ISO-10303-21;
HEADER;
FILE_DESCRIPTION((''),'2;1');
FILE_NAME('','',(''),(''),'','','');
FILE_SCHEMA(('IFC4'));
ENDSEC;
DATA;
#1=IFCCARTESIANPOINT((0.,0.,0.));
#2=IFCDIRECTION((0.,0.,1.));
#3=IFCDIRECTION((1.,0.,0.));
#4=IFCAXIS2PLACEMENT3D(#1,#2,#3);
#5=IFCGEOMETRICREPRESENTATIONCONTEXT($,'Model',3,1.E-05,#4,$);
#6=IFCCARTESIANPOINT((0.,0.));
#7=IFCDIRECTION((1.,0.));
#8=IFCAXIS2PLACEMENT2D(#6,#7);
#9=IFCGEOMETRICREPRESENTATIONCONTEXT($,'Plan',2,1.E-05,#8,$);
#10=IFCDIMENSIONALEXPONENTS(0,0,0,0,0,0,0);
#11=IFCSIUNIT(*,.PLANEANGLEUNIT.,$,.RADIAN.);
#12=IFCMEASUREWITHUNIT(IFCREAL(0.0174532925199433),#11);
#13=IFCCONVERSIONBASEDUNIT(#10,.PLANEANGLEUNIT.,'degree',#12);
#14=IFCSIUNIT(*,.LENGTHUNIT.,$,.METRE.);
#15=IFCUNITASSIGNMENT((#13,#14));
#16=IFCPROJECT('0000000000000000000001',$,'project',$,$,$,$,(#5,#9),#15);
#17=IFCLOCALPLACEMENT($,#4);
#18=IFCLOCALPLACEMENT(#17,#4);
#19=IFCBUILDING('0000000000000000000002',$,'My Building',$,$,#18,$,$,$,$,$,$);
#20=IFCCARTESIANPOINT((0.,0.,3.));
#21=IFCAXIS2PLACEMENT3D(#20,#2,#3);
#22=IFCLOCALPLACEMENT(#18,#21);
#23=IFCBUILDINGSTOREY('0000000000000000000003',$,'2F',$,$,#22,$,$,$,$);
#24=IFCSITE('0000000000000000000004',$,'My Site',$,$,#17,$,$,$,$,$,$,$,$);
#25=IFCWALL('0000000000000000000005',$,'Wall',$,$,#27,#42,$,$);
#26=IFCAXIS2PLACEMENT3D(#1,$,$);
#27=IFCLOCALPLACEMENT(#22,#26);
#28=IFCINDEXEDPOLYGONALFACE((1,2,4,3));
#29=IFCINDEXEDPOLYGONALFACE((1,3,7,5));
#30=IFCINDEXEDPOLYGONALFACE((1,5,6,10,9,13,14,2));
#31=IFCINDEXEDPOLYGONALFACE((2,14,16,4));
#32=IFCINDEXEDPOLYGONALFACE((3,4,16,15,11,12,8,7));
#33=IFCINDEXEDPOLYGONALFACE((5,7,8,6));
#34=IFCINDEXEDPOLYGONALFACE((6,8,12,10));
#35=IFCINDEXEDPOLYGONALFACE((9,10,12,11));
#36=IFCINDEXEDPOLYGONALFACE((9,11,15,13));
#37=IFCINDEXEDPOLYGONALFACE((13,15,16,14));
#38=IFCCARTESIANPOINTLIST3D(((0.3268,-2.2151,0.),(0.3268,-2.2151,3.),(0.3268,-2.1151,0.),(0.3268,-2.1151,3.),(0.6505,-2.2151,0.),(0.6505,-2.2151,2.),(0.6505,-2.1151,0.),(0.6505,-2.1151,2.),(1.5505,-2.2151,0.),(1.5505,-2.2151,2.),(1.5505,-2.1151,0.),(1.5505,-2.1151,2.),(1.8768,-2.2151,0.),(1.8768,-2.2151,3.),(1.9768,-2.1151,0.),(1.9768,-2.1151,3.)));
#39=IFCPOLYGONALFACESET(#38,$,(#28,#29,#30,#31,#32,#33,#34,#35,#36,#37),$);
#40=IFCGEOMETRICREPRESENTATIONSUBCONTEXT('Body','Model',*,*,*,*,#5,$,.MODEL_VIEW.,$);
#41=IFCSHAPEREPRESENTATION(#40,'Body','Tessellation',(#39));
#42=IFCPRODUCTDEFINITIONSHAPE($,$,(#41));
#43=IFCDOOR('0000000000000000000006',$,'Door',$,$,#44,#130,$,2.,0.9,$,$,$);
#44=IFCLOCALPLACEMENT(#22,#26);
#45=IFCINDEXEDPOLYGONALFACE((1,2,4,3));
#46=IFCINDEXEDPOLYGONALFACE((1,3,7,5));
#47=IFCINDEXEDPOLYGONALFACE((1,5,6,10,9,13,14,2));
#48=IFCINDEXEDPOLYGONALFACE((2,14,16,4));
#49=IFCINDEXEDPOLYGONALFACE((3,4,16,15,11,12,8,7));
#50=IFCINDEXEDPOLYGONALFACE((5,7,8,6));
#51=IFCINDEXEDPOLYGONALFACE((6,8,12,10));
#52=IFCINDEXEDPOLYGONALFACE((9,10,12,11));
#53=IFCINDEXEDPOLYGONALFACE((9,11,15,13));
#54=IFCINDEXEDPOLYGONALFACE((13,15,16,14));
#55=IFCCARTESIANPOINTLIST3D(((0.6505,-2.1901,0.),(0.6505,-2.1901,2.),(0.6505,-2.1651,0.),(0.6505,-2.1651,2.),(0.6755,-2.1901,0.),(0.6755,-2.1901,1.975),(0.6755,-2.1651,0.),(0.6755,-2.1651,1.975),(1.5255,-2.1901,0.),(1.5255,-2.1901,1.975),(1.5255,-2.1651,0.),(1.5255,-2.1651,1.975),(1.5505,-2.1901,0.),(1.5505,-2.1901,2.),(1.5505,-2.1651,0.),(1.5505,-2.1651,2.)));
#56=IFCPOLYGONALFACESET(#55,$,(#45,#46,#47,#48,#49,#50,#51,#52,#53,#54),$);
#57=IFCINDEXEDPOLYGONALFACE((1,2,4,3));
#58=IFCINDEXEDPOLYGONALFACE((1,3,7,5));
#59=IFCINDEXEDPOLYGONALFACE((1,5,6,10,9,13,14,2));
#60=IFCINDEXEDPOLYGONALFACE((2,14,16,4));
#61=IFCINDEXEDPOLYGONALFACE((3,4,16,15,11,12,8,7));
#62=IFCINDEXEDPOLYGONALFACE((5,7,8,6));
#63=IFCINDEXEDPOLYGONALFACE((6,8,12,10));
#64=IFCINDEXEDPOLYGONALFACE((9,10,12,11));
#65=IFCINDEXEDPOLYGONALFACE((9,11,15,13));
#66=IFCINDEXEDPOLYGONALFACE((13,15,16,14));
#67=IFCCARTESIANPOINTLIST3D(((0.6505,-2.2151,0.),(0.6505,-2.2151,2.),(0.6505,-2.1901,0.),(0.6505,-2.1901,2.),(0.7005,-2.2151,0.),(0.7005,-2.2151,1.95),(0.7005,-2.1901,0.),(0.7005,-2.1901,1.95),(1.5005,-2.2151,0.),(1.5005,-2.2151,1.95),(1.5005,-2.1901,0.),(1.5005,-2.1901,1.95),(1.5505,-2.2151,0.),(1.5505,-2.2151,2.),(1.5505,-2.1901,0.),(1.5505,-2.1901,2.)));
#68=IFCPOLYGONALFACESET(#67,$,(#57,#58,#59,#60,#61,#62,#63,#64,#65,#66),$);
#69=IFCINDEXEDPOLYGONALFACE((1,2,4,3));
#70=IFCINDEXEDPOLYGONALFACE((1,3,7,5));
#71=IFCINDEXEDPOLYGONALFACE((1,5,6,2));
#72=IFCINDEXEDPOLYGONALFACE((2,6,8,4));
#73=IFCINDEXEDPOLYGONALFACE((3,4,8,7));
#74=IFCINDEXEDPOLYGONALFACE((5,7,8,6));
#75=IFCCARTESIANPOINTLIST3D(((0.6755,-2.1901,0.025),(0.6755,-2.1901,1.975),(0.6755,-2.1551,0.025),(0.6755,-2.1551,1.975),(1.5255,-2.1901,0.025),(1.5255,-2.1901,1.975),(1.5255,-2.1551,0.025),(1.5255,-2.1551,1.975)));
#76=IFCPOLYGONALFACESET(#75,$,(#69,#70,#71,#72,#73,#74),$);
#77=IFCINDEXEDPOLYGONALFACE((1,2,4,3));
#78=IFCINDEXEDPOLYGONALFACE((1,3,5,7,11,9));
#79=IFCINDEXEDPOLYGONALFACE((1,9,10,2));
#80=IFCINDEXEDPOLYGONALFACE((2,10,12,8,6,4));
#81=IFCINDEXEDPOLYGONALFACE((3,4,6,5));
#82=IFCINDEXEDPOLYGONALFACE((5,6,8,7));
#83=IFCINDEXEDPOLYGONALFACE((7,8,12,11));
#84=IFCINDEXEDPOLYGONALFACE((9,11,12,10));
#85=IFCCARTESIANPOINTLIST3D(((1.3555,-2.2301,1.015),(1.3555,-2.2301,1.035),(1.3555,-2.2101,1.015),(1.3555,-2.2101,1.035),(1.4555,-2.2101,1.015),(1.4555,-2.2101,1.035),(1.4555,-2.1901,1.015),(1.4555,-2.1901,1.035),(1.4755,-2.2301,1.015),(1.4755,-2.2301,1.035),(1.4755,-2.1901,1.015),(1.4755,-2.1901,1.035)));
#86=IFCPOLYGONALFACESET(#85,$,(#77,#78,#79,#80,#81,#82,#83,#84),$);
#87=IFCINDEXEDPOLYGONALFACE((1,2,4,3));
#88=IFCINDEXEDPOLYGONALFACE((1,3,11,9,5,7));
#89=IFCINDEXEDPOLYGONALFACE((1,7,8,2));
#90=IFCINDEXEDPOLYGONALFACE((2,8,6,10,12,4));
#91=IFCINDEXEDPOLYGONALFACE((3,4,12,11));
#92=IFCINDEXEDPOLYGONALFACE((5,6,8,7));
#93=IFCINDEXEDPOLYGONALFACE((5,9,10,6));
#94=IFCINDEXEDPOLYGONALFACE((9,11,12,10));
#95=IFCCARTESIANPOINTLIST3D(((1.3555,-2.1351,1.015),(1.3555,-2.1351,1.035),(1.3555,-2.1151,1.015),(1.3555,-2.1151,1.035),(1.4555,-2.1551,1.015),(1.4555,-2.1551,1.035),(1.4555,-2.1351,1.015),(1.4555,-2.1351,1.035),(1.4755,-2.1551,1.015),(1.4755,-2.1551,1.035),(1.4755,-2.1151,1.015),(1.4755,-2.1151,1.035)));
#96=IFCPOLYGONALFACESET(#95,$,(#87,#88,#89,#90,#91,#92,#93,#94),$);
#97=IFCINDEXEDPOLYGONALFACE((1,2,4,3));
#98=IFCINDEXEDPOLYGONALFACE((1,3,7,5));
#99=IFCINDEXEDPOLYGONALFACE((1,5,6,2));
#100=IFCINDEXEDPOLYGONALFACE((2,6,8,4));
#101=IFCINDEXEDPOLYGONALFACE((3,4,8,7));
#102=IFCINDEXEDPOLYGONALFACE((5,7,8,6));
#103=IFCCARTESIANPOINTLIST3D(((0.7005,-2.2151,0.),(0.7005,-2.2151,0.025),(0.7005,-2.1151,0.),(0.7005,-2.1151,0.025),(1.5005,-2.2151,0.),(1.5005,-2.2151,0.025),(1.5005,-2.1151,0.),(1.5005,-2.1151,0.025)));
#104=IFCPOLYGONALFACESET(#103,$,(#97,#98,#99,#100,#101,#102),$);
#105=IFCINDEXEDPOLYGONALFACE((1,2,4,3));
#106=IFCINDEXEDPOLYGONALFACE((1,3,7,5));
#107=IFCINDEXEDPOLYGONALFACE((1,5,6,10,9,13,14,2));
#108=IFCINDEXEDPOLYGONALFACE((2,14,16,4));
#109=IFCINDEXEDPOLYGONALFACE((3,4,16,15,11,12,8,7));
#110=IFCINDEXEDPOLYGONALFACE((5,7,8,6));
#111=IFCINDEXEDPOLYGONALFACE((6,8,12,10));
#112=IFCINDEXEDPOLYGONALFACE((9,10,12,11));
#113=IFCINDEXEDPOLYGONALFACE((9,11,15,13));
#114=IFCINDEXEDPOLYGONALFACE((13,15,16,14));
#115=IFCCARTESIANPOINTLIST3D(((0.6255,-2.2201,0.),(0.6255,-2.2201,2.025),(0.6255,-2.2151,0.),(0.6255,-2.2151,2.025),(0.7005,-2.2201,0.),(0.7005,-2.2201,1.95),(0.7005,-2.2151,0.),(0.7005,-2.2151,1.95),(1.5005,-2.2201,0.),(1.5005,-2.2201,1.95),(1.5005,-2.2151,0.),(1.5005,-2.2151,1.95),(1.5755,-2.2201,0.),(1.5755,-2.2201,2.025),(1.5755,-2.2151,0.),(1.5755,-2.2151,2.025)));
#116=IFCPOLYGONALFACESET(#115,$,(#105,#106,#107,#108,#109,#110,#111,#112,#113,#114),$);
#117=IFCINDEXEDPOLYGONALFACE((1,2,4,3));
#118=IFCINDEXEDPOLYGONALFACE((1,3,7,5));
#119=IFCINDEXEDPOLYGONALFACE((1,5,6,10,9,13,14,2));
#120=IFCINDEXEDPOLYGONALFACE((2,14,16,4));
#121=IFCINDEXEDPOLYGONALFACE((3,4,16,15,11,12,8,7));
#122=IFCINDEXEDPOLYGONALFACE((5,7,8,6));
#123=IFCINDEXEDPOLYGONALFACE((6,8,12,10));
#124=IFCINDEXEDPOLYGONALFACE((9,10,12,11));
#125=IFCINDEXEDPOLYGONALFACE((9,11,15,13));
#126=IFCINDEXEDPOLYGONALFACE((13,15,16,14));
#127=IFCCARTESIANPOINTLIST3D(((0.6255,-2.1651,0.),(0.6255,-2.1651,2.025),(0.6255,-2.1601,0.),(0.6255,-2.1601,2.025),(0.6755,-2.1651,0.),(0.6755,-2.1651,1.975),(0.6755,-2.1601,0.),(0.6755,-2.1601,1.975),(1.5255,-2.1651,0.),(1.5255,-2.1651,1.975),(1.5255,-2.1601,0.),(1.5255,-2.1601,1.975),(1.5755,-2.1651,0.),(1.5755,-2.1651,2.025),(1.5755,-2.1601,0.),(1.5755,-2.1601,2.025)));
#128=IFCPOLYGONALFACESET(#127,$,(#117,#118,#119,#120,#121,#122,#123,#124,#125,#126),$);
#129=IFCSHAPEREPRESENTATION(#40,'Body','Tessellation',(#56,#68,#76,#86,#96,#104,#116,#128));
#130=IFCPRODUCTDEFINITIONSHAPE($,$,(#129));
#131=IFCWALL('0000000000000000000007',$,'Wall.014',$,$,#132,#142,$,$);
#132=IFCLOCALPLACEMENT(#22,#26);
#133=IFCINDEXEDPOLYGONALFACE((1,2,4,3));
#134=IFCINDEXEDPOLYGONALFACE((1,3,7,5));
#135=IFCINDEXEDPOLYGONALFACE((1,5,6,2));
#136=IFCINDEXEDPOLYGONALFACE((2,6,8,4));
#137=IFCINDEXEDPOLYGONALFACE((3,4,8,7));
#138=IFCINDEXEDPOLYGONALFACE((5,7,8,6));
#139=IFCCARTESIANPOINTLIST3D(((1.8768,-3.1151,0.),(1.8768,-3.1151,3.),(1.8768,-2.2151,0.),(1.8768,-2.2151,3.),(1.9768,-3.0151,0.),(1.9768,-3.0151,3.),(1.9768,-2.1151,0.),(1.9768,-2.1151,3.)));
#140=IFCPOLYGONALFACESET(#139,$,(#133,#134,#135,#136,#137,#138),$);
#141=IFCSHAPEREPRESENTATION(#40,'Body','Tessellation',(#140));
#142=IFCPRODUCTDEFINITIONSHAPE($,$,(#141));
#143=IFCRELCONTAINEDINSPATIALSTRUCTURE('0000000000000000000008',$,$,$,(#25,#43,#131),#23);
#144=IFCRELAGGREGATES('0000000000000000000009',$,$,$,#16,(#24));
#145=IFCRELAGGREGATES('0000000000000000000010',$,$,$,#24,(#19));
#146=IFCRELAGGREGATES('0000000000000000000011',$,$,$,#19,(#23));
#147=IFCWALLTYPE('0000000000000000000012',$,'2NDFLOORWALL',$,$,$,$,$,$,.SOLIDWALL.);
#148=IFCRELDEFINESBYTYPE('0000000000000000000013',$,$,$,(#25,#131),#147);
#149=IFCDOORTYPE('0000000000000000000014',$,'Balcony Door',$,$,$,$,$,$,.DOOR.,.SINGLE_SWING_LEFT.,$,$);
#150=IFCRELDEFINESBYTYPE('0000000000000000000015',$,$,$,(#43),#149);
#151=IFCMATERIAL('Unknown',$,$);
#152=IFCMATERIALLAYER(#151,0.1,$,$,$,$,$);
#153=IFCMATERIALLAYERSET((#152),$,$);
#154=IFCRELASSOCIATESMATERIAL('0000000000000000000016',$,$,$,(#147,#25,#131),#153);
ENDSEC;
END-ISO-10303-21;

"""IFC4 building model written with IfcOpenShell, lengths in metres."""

from ifc_helpers import new_model, entity, si_unit, converted_unit, frame, origin_with_axes, origin_2d_with_axis, place, context, subcontext, project, spatial, line, indexed_curve, outline, extrude, shape, source, transform, mapped, material, layer, layer_set, layer_usage, type_object, type_shapes, element, fill, save


model = new_model("IFC4")

# Units and contexts
model_context = context("Model", 3, precision=1e-05, world=origin_with_axes())
plan_context = context("Plan", 2, precision=1e-05, world=origin_2d_with_axis())
body_context_1 = subcontext(model_context, "Body", "Model", "MODEL_VIEW")
body_context_2 = subcontext(plan_context, "Body", "Plan", "PLAN_VIEW")
ifc_project = project(units=[converted_unit("PLANEANGLEUNIT", "degree", entity("IfcReal", 0.0174532925199433), si_unit("PLANEANGLEUNIT", "RADIAN"), dimensions=[0, 0, 0, 0, 0, 0, 0]), si_unit("LENGTHUNIT", "METRE")], contexts=[model_context, plan_context])

# Site, building, storey
site_placement = place(None, origin_with_axes())
site = spatial("IfcSite", under=ifc_project, at=site_placement, Name="My Site")
building_placement = place(site_placement, origin_with_axes())
building = spatial("IfcBuilding", under=site, at=building_placement, Name="My Building")
storey_placement = place(building_placement, frame((0.0, 0.0, 3.0), z_axis=(0.0, 0.0, 1.0), x_axis=(1.0, 0.0, 0.0)))
storey = spatial("IfcBuildingStorey", under=building, at=storey_placement, Name="2F")

# Shared definitions
ifc_material = material(Name="Unknown")

# Wall, opening, door
ifc_layer_1 = layer(ifc_material, 0.1)
ifc_layer_set_1 = layer_set([ifc_layer_1])
ifc_layer_usage_1 = layer_usage(ifc_layer_set_1, "AXIS2", "POSITIVE", 0.0)
wall_type_1 = type_object("IfcWallType", Name="2NDFLOORWALL", PredefinedType="SOLIDWALL", material=ifc_layer_set_1)
wall_1_placement = place(storey_placement, frame((0.3268, -2.2151, 0.0), z_axis=(0.0, 0.0, 1.0), x_axis=(1.0, 0.0, 0.0)))
wall_1 = element("IfcWall", 1, at=wall_1_placement, inside=storey, type_object=wall_type_1, material=ifc_layer_usage_1, Name="Wall", context=body_context_1, shape_type="SweptSolid", body=[
    extrude(outline(indexed_curve([(0.0, 0.0), (0.0, 0.1), (1.65, 0.1), (1.55, 0.0)], segments=[line(1, 2, 3, 4, 1)])), origin_with_axes(), (0.0, 0.0, 1.0), 3.0),
])
shared_shape_1 = source(origin_with_axes(), body_context_1, "Body", "SweptSolid", [
    extrude(outline(indexed_curve([(0.0, 0.0), (0.9, 0.0), (0.9, 2.0), (0.0, 2.0)], segments=[line(1, 2, 3, 4, 1)])), frame((0.0, -0.6, 0.0), z_axis=(0.0, -1.0, 0.0), x_axis=(1.0, 0.0, 0.0)), (0.0, 0.0, -1.0), 1.2),
])
opening_1_placement = place(wall_1_placement, frame((0.3237, 0.0, 0.0), z_axis=(0.0, 0.0, 1.0), x_axis=(1.0, 0.0, 0.0)))
opening_1 = element("IfcOpeningElement", 2, at=opening_1_placement, cuts=wall_1, PredefinedType="OPENING", context=body_context_1, shape_type="MappedRepresentation", body=[
    mapped(shared_shape_1, transform((0.0, 0.0, 0.0), x_axis=(1.0, 0.0, 0.0), y_axis=(0.0, 1.0, 0.0), z_axis=(0.0, 0.0, 1.0), scale=1.0)),
])
door_type_1 = type_object("IfcDoorType", Name="Balcony Door", OperationType="SINGLE_SWING_LEFT", PredefinedType="DOOR")
shared_shape_2 = source(origin_with_axes(), body_context_1, "Body", "SweptSolid", [
    extrude(outline(indexed_curve([(0.0, 0.0), (0.0, 2.0), (0.9, 2.0), (0.9, 0.0), (0.875, 0.0), (0.875, 1.975), (0.025, 1.975), (0.025, 0.0)], segments=[line(1, 2, 3, 4, 5, 6, 7, 8, 1)])), frame((0.0, 0.025, 0.0), z_axis=(0.0, -1.0, 0.0), x_axis=(1.0, 0.0, 0.0)), (0.0, 0.0, -1.0), 0.025),
    extrude(outline(indexed_curve([(0.0, 0.0), (0.0, 2.0), (0.9, 2.0), (0.9, 0.0), (0.85, 0.0), (0.85, 1.95), (0.05, 1.95), (0.05, 0.0)], segments=[line(1, 2, 3, 4, 5, 6, 7, 8, 1)])), frame((0.0, 0.0, 0.0), z_axis=(0.0, -1.0, 0.0), x_axis=(1.0, 0.0, 0.0)), (0.0, 0.0, -1.0), 0.025),
    extrude(outline(indexed_curve([(0.0, 0.0), (0.85, 0.0), (0.85, 0.035), (0.0, 0.035)], segments=[line(1, 2, 3, 4, 1)])), frame((0.025, 0.025, 0.025), z_axis=(0.0, 0.0, 1.0), x_axis=(1.0, 0.0, 0.0)), (0.0, 0.0, 1.0), 1.95),
    extrude(outline(indexed_curve([(0.0, 0.0), (0.0, -0.04), (-0.12, -0.04), (-0.12, -0.02), (-0.02, -0.02), (-0.02, 0.0)], segments=[line(1, 2, 3, 4, 5, 6, 1)])), frame((0.825, 0.025, 1.015), z_axis=(0.0, 0.0, 1.0), x_axis=(1.0, 0.0, 0.0)), (0.0, 0.0, 1.0), 0.02),
    extrude(outline(indexed_curve([(0.0, 0.0), (0.0, 0.04), (-0.12, 0.04), (-0.12, 0.02), (-0.02, 0.02), (-0.02, 0.0)], segments=[line(1, 2, 3, 4, 5, 6, 1)])), frame((0.825, 0.06, 1.015), z_axis=(0.0, 0.0, 1.0), x_axis=(1.0, 0.0, 0.0)), (0.0, 0.0, 1.0), 0.02),
    extrude(outline(indexed_curve([(0.0, 0.0), (0.8, 0.0), (0.8, 0.1), (0.0, 0.1)], segments=[line(1, 2, 3, 4, 1)])), frame((0.05, 0.0, 0.0), z_axis=(0.0, 0.0, 1.0), x_axis=(1.0, 0.0, 0.0)), (0.0, 0.0, 1.0), 0.025),
    extrude(outline(indexed_curve([(0.0, 0.0), (0.0, 2.025), (0.95, 2.025), (0.95, 0.0), (0.875, 0.0), (0.875, 1.95), (0.075, 1.95), (0.075, 0.0)], segments=[line(1, 2, 3, 4, 5, 6, 7, 8, 1)])), frame((-0.025, -0.005, 0.0), z_axis=(0.0, -1.0, 0.0), x_axis=(1.0, 0.0, 0.0)), (0.0, 0.0, -1.0), 0.005),
    extrude(outline(indexed_curve([(0.0, 0.0), (0.0, 2.025), (0.95, 2.025), (0.95, 0.0), (0.9, 0.0), (0.9, 1.975), (0.05, 1.975), (0.05, 0.0)], segments=[line(1, 2, 3, 4, 5, 6, 7, 8, 1)])), frame((-0.025, 0.05, 0.0), z_axis=(0.0, -1.0, 0.0), x_axis=(1.0, 0.0, 0.0)), (0.0, 0.0, -1.0), 0.005),
])
shared_shape_3 = source(origin_with_axes(), body_context_2, "Body", "Curve2D", [
    entity("IfcIndexedPolyCurve", entity("IfcCartesianPointList2D", [[0.0, 0.0], [0.0, 0.05], [0.025, 0.05], [0.025, 0.025], [0.05, 0.025], [0.05, 0.0]]), [entity("IfcLineIndex", [1, 2, 3, 4, 5, 6, 1])]),
    entity("IfcIndexedPolyCurve", entity("IfcCartesianPointList2D", [[0.9, 0.0], [0.9, 0.05], [0.875, 0.05], [0.875, 0.025], [0.85, 0.025], [0.85, 0.0]]), [entity("IfcLineIndex", [1, 2, 3, 4, 5, 6, 1])]),
    entity("IfcTrimmedCurve", entity("IfcEllipse", entity("IfcAxis2Placement2D", entity("IfcCartesianPoint", [0.06, 0.05]), entity("IfcDirection", [1.0, 0.0])), 0.815, 0.85), [entity("IfcCartesianPoint", [0.875, 0.05])], [entity("IfcCartesianPoint", [0.06, 0.9])], True, "CARTESIAN"),
    entity("IfcIndexedPolyCurve", entity("IfcCartesianPointList2D", [[0.025, 0.05], [0.06, 0.05], [0.06, 0.9], [0.025, 0.9]]), [entity("IfcLineIndex", [1, 2, 3, 4, 1])]),
])
type_shapes(door_type_1, [shared_shape_2, shared_shape_3])
door_1_placement = place(opening_1_placement, origin_with_axes())
door_1 = element("IfcDoor", 3, at=door_1_placement, inside=storey, type_object=door_type_1, Name="Door", OverallHeight=2.0, OverallWidth=0.9, shapes=[
    shape(body_context_1, "Body", "MappedRepresentation", [mapped(shared_shape_2, transform((0.0, 0.0, 0.0), x_axis=(1.0, 0.0, 0.0), y_axis=(0.0, 1.0, 0.0), z_axis=(0.0, 0.0, 1.0), scale=1.0))]),
    shape(body_context_2, "Body", "MappedRepresentation", [mapped(shared_shape_3, transform((0.0, 0.0, 0.0), x_axis=(1.0, 0.0, 0.0), y_axis=(0.0, 1.0, 0.0), z_axis=(0.0, 0.0, 1.0), scale=1.0))]),
])
fill(opening_1, door_1)

# Wall
ifc_layer_usage_2 = layer_usage(ifc_layer_set_1, "AXIS2", "POSITIVE", 0.0)
wall_2_placement = place(storey_placement, frame((1.8768, -2.2151, 0.0), z_axis=(0.0, 0.0, 1.0), x_axis=(0.0, -1.0, 0.0)))
element("IfcWall", 4, at=wall_2_placement, inside=storey, type_object=wall_type_1, material=ifc_layer_usage_2, Name="Wall.014", context=body_context_1, shape_type="SweptSolid", body=[
    extrude(outline(indexed_curve([(0.0, 0.0), (-0.1, 0.1), (0.8, 0.1), (0.9, 0.0)], segments=[line(1, 2, 3, 4, 1)])), origin_with_axes(), (0.0, 0.0, 1.0), 3.0),
])

save(model, "model.ifc")
